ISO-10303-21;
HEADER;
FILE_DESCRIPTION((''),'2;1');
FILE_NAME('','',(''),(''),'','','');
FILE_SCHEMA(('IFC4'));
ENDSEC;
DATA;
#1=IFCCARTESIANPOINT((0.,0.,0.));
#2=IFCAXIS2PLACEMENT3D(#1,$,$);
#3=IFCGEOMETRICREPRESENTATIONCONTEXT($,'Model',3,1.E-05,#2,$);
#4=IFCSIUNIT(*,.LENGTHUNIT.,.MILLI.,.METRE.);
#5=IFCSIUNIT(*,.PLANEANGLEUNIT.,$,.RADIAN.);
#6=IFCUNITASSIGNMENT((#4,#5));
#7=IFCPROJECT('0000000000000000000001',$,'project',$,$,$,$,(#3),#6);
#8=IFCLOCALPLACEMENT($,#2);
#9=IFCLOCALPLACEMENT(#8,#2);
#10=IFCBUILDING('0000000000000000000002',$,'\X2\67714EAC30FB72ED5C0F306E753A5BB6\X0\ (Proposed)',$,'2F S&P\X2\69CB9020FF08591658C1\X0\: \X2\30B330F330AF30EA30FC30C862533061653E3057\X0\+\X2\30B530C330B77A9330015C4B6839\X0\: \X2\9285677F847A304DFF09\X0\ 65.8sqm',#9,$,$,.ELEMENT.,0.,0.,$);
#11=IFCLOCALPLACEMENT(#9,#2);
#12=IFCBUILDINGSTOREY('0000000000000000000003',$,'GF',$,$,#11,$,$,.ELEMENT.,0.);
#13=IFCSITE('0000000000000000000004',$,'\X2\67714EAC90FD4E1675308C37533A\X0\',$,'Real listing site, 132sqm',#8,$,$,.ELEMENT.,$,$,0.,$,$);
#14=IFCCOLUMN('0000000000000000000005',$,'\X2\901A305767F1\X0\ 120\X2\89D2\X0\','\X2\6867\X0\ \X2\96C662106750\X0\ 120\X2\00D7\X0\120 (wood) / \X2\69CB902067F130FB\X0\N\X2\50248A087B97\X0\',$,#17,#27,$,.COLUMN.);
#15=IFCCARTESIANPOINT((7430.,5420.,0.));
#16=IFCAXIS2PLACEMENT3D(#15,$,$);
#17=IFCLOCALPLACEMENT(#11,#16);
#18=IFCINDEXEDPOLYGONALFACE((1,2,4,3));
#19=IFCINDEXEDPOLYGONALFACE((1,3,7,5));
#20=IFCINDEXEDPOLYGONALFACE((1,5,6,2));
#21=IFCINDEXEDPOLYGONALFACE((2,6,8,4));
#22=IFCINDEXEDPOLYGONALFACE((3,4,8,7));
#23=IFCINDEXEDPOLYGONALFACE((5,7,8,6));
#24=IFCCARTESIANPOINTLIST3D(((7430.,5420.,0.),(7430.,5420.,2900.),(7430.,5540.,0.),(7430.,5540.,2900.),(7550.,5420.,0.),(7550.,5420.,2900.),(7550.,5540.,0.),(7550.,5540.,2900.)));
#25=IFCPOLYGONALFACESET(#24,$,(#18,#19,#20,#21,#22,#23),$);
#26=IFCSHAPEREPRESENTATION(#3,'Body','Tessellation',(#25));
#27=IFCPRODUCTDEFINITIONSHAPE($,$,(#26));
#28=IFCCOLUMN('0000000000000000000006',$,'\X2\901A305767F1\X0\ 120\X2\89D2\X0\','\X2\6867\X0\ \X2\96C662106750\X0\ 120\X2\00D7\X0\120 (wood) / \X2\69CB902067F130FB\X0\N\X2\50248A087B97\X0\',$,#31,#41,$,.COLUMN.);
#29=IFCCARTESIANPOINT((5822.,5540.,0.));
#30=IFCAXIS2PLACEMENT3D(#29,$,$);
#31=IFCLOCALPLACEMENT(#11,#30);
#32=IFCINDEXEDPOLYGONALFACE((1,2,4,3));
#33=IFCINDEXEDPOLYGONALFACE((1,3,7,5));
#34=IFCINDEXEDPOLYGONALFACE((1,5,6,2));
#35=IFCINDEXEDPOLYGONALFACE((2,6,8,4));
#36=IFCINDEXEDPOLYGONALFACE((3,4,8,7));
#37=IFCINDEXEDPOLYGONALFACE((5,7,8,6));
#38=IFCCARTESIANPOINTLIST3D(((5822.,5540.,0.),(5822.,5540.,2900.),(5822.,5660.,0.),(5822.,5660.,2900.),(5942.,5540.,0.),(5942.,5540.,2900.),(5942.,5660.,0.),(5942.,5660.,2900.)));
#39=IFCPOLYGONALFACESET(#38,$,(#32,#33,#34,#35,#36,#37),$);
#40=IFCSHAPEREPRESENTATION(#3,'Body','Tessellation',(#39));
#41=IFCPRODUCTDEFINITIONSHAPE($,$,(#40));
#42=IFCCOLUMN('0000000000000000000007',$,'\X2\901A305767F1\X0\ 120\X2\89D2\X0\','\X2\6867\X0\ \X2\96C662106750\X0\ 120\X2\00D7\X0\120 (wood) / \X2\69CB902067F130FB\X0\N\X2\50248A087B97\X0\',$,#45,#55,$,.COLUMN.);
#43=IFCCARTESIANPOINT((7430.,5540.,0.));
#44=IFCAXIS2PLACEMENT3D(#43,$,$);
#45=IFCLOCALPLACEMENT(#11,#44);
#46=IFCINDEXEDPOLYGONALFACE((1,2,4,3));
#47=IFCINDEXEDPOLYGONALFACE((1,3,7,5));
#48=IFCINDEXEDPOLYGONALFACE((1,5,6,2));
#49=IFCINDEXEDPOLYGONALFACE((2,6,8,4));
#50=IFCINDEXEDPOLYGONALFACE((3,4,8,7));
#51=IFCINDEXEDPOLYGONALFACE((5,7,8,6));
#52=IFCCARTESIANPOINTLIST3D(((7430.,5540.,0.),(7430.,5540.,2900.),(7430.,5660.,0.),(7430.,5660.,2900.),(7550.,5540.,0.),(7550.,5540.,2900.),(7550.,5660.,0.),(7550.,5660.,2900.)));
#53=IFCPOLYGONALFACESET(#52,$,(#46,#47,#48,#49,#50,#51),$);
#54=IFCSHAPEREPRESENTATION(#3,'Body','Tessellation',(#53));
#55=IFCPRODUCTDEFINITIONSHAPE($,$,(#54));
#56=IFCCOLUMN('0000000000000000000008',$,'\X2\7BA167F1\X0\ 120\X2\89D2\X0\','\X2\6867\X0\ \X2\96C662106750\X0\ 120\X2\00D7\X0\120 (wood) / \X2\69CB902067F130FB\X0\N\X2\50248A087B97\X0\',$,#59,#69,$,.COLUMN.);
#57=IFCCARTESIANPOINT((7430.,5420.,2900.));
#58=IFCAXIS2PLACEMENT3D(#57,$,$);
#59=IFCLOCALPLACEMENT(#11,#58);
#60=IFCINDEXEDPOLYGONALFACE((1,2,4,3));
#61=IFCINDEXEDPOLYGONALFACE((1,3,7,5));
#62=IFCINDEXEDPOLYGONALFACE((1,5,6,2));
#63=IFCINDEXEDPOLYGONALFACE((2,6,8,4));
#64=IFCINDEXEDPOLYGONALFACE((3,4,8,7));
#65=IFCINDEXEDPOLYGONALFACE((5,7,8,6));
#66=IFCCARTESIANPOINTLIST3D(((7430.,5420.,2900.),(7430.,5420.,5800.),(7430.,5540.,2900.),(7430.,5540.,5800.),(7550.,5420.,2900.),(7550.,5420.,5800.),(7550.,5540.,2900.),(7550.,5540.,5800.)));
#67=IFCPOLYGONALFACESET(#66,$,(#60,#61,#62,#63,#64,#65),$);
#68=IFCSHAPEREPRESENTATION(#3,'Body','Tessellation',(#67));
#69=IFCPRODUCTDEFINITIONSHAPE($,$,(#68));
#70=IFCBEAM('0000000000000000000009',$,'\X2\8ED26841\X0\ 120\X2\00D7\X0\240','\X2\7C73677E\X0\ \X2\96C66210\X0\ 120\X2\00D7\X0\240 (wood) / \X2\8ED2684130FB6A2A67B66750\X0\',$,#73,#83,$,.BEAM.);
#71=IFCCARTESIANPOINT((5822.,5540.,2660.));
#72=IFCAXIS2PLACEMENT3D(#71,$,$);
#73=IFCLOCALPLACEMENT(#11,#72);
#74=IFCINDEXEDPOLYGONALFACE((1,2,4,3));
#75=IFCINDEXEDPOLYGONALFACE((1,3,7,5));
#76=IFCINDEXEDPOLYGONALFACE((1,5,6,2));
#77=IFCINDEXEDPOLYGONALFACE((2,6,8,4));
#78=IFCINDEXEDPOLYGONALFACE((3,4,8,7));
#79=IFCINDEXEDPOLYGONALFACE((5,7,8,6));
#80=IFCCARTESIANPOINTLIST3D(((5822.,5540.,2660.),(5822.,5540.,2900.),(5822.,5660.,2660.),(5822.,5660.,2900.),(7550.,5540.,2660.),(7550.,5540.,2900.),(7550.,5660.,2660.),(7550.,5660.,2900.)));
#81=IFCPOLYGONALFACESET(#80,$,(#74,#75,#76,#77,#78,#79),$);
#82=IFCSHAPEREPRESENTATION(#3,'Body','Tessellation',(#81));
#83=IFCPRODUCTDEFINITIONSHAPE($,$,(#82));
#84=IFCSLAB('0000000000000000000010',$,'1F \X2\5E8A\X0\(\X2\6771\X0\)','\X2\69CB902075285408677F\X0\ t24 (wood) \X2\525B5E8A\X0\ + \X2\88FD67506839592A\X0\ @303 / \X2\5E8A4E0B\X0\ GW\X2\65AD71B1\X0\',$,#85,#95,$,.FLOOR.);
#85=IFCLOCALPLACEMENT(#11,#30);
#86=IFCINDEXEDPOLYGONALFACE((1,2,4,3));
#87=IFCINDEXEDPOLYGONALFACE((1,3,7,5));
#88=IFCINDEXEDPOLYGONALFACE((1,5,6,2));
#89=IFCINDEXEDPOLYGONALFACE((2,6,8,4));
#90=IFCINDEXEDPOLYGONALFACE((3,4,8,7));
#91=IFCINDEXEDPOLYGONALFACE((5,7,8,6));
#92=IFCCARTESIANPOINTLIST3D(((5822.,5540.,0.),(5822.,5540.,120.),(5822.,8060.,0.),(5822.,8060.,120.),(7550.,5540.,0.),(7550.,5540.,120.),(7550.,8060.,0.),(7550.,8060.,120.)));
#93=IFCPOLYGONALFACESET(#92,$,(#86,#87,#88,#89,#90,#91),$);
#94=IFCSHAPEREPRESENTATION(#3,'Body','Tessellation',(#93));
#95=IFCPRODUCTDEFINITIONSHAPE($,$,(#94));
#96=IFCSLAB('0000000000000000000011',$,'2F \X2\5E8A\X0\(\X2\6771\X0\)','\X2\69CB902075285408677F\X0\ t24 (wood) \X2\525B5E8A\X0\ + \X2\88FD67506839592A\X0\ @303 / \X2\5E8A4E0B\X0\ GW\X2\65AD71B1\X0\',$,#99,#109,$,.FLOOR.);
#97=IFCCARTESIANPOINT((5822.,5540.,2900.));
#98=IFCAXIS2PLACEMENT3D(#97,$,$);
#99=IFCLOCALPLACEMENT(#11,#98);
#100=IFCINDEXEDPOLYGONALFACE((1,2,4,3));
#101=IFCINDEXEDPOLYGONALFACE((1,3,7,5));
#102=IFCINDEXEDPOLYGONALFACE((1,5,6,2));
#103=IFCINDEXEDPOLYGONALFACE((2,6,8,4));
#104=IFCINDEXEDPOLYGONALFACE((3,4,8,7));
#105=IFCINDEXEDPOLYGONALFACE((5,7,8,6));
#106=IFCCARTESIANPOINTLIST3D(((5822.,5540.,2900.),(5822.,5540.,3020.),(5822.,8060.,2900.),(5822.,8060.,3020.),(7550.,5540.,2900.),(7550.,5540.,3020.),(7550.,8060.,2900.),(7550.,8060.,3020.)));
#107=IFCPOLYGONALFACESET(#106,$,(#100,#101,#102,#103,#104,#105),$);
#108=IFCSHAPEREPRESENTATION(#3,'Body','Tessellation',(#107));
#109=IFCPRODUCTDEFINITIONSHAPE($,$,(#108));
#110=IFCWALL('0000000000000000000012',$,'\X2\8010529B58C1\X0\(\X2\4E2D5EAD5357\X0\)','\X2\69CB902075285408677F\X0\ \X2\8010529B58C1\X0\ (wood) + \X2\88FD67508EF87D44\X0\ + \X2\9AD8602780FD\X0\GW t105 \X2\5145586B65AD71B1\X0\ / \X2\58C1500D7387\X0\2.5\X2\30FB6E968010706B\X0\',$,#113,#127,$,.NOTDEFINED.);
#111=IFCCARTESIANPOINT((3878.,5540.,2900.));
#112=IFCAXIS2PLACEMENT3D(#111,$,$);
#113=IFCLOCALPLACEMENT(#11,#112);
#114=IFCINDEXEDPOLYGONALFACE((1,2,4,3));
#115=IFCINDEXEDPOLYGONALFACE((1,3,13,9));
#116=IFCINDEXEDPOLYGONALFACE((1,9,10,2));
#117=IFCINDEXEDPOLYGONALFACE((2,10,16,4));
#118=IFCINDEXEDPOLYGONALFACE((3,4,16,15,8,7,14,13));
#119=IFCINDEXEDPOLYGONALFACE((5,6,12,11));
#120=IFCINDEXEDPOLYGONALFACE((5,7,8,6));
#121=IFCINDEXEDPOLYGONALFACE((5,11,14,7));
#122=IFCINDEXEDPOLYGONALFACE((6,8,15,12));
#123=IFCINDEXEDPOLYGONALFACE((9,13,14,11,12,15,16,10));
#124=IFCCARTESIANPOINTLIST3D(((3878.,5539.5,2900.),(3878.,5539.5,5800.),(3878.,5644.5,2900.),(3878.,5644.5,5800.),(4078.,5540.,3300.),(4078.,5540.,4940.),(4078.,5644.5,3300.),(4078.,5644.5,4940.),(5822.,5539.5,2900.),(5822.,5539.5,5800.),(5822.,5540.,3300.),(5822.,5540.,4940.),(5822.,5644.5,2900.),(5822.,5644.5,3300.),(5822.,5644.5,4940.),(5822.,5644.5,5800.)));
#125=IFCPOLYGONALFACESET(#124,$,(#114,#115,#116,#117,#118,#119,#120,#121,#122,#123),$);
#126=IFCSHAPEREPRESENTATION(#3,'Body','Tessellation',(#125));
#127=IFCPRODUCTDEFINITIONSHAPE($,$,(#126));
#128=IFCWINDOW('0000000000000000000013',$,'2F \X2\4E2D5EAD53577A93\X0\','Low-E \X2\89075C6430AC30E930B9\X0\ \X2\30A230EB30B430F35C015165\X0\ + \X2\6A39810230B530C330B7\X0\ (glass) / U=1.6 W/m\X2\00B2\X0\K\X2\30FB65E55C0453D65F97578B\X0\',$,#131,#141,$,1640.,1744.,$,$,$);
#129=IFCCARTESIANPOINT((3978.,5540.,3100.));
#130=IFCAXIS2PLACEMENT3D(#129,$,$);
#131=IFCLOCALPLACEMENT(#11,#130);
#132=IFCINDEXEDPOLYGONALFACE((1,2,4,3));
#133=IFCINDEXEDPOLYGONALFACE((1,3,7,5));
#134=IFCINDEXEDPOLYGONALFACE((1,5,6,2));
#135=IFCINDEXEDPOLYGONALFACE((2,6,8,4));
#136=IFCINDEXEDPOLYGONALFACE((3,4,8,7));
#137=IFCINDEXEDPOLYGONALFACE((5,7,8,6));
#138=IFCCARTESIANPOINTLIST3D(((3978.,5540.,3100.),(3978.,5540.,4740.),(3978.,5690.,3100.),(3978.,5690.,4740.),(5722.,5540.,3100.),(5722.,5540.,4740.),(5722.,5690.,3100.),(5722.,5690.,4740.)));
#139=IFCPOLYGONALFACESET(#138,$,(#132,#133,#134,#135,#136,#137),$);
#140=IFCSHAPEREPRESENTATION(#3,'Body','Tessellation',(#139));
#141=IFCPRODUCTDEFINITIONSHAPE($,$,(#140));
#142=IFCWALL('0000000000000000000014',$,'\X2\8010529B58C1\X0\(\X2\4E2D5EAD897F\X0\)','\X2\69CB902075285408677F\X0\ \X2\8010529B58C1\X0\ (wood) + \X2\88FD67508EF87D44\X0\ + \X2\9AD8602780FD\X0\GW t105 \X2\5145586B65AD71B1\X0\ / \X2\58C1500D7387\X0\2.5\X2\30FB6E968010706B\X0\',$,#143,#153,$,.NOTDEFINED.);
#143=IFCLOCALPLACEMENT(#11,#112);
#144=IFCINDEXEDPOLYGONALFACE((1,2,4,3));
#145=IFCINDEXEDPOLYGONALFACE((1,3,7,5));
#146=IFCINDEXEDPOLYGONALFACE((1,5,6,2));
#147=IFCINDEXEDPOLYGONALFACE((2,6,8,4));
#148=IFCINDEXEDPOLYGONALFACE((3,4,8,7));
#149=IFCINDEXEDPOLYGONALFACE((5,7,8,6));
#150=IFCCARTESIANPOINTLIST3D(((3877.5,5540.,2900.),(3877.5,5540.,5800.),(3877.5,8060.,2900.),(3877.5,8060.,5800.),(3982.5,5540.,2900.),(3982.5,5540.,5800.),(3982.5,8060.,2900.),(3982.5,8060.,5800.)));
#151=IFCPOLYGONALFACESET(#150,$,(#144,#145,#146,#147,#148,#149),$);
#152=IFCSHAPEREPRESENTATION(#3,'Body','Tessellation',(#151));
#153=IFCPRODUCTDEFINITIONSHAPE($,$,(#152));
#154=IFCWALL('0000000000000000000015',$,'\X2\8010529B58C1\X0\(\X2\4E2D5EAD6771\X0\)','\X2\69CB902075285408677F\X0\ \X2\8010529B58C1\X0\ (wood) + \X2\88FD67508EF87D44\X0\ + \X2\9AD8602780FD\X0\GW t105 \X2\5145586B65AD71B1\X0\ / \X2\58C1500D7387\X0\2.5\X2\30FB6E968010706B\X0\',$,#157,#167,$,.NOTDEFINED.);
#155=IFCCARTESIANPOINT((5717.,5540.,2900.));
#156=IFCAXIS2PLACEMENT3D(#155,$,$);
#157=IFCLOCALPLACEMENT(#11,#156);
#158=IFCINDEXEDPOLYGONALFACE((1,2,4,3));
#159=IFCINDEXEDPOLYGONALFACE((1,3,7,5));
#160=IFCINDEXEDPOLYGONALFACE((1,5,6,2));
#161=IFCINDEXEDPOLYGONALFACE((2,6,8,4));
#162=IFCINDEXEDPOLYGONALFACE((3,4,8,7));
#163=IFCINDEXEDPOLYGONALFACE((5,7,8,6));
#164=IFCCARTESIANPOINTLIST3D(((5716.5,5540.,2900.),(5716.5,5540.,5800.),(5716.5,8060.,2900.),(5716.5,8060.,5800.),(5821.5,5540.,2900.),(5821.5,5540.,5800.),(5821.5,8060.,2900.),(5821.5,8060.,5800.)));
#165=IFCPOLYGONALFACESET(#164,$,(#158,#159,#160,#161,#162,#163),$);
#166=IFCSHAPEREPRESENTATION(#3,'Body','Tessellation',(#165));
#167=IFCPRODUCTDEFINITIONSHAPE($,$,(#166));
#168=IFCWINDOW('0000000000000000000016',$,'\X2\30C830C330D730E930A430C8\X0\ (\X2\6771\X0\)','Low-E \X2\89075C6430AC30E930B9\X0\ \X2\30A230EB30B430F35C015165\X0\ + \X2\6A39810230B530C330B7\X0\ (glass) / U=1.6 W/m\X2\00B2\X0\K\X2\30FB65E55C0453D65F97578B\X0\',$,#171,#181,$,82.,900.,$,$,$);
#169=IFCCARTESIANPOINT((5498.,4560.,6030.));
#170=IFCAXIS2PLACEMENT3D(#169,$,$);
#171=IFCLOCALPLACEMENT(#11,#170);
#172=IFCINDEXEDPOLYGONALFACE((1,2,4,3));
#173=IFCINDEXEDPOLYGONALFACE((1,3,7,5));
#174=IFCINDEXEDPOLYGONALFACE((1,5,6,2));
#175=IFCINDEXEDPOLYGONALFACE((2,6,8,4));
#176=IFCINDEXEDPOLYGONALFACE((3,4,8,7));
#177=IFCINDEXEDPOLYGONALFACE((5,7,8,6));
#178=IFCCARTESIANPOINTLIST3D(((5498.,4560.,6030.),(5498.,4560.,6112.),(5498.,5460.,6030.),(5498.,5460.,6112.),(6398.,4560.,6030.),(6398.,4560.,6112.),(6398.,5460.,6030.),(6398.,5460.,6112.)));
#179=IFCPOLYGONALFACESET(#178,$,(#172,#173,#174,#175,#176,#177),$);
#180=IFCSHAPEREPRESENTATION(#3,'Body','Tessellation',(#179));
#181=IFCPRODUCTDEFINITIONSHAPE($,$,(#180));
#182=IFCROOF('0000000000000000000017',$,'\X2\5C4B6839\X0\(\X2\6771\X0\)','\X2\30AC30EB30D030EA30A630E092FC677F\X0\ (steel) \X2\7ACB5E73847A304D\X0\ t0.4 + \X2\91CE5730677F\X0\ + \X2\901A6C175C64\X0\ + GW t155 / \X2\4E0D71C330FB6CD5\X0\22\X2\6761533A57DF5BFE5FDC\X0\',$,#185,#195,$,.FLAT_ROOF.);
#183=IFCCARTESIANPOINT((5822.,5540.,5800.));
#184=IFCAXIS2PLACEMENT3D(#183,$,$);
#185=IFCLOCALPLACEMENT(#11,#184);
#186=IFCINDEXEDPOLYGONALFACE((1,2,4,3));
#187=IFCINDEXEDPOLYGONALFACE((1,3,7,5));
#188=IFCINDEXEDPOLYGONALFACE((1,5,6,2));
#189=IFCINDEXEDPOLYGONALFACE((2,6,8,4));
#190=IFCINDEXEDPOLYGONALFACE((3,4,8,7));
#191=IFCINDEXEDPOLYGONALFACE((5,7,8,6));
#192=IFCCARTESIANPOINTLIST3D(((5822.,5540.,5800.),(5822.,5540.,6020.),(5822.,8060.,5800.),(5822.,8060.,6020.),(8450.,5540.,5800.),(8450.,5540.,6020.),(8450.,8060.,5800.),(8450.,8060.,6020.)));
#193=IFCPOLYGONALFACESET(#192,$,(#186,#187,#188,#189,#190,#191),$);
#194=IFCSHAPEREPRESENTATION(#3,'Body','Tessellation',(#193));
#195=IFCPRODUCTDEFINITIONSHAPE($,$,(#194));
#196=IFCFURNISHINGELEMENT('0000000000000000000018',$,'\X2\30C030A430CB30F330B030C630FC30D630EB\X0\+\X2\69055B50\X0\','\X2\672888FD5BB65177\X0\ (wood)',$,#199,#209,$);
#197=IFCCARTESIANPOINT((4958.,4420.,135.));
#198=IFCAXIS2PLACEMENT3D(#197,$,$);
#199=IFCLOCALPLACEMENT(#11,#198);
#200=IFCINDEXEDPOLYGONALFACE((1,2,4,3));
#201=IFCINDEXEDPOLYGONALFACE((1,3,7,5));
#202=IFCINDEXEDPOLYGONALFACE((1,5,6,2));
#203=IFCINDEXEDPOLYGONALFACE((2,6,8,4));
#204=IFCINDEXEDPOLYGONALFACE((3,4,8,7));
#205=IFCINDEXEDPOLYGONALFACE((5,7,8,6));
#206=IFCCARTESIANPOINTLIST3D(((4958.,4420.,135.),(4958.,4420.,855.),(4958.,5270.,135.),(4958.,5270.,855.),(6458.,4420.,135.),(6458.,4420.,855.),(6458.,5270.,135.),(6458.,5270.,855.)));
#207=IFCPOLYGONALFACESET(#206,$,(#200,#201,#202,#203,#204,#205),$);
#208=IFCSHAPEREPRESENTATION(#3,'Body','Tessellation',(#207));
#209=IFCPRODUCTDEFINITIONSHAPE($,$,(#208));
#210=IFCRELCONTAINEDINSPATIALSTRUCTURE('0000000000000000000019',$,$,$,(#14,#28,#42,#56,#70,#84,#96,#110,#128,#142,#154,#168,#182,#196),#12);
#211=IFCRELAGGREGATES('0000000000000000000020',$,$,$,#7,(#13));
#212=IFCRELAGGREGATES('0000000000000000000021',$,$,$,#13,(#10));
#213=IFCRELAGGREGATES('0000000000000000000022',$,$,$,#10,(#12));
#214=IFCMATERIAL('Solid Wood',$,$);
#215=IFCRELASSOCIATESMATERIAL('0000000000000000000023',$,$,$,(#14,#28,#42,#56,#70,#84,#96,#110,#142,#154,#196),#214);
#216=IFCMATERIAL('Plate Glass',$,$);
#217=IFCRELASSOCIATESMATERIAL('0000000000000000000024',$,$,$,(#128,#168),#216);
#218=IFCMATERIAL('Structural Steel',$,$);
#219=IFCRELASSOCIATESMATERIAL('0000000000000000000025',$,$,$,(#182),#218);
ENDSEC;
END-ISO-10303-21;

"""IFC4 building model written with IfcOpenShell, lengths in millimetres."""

from ifc_helpers import new_model, si_unit, frame, frame_2d, origin, place, context, project, spatial, rectangle, extrude, material, element, fill, save


model = new_model("IFC4")

# Units and contexts
model_context = context("Model", 3, precision=1e-05, world=origin())
ifc_project = project(units=[si_unit("LENGTHUNIT", "METRE", prefix="MILLI"), si_unit("PLANEANGLEUNIT", "RADIAN")], contexts=[model_context])

# Site, building, storey
site_placement = place(None, origin())
site = spatial("IfcSite", under=ifc_project, at=site_placement, Name="東京都世田谷区", ObjectType="Real listing site, 132sqm", CompositionType="ELEMENT", RefElevation=0.0)
building_placement = place(site_placement, origin())
building = spatial("IfcBuilding", under=site, at=building_placement, Name="東京・狭小の町家 (Proposed)", ObjectType="2F S&P構造（外壁: コンクリート打ち放し+サッシ窓、屋根: 銅板葺き） 65.8sqm", CompositionType="ELEMENT", ElevationOfRefHeight=0.0, ElevationOfTerrain=0.0)
storey_placement = place(building_placement, origin())
storey = spatial("IfcBuildingStorey", under=building, at=storey_placement, Name="GF", CompositionType="ELEMENT", Elevation=0.0)

# Columns
ifc_material_1 = material(Name="Solid Wood")
column_1_placement = place(storey_placement, frame((7430.0, 5420.0, 0.0)))
element("IfcColumn", 1, at=column_1_placement, inside=storey, material=ifc_material_1, Name="通し柱 120角", Description="桧 集成材 120×120 (wood) / 構造柱・N値計算", PredefinedType="COLUMN", context=model_context, shape_type="SweptSolid", body=[
    extrude(rectangle(XDim=120.0, YDim=120.0, at=frame_2d((60.0, 60.0))), frame((7430.0, 5420.0, 0.0)), (0.0, 0.0, 1.0), 2900.0),
])
column_2_placement = place(storey_placement, frame((5822.0, 5540.0, 0.0)))
element("IfcColumn", 2, at=column_2_placement, inside=storey, material=ifc_material_1, Name="通し柱 120角", Description="桧 集成材 120×120 (wood) / 構造柱・N値計算", PredefinedType="COLUMN", context=model_context, shape_type="SweptSolid", body=[
    extrude(rectangle(XDim=120.0, YDim=120.0, at=frame_2d((60.0, 60.0))), frame((5822.0, 5540.0, 0.0)), (0.0, 0.0, 1.0), 2900.0),
])
column_3_placement = place(storey_placement, frame((7430.0, 5540.0, 0.0)))
element("IfcColumn", 3, at=column_3_placement, inside=storey, material=ifc_material_1, Name="通し柱 120角", Description="桧 集成材 120×120 (wood) / 構造柱・N値計算", PredefinedType="COLUMN", context=model_context, shape_type="SweptSolid", body=[
    extrude(rectangle(XDim=120.0, YDim=120.0, at=frame_2d((60.0, 60.0))), frame((7430.0, 5540.0, 0.0)), (0.0, 0.0, 1.0), 2900.0),
])
column_4_placement = place(storey_placement, frame((7430.0, 5420.0, 2900.0)))
element("IfcColumn", 4, at=column_4_placement, inside=storey, material=ifc_material_1, Name="管柱 120角", Description="桧 集成材 120×120 (wood) / 構造柱・N値計算", PredefinedType="COLUMN", context=model_context, shape_type="SweptSolid", body=[
    extrude(rectangle(XDim=120.0, YDim=120.0, at=frame_2d((60.0, 60.0))), frame((7430.0, 5420.0, 2900.0)), (0.0, 0.0, 1.0), 2900.0),
])

# Beam
beam_1_placement = place(storey_placement, frame((5822.0, 5540.0, 2660.0)))
element("IfcBeam", 5, at=beam_1_placement, inside=storey, material=ifc_material_1, Name="軒桁 120×240", Description="米松 集成 120×240 (wood) / 軒桁・横架材", PredefinedType="BEAM", context=model_context, shape_type="SweptSolid", body=[
    extrude(rectangle(XDim=1728.0, YDim=120.0, at=frame_2d((864.0, 60.0))), frame((5822.0, 5540.0, 2660.0)), (0.0, 0.0, 1.0), 240.0),
])

# Slabs
slab_1_placement = place(storey_placement, frame((5822.0, 5540.0, 0.0)))
element("IfcSlab", 6, at=slab_1_placement, inside=storey, material=ifc_material_1, Name="1F 床(東)", Description="構造用合板 t24 (wood) 剛床 + 製材根太 @303 / 床下 GW断熱", PredefinedType="FLOOR", context=model_context, shape_type="SweptSolid", body=[
    extrude(rectangle(XDim=1728.0, YDim=2520.0, at=frame_2d((864.0, 1260.0))), frame((5822.0, 5540.0, 0.0)), (0.0, 0.0, 1.0), 120.0),
])
slab_2_placement = place(storey_placement, frame((5822.0, 5540.0, 2900.0)))
element("IfcSlab", 7, at=slab_2_placement, inside=storey, material=ifc_material_1, Name="2F 床(東)", Description="構造用合板 t24 (wood) 剛床 + 製材根太 @303 / 床下 GW断熱", PredefinedType="FLOOR", context=model_context, shape_type="SweptSolid", body=[
    extrude(rectangle(XDim=1728.0, YDim=2520.0, at=frame_2d((864.0, 1260.0))), frame((5822.0, 5540.0, 2900.0)), (0.0, 0.0, 1.0), 120.0),
])

# Wall, opening, window
wall_1_placement = place(storey_placement, frame((3878.0, 5540.0, 2900.0)))
wall_1 = element("IfcWall", 8, at=wall_1_placement, inside=storey, material=ifc_material_1, Name="耐力壁(中庭南)", Description="構造用合板 耐力壁 (wood) + 製材軸組 + 高性能GW t105 充填断熱 / 壁倍率2.5・準耐火", PredefinedType="NOTDEFINED", context=model_context, shape_type="SweptSolid", body=[
    extrude(rectangle(XDim=1944.0, YDim=105.0, at=frame_2d((972.0, 52.0))), frame((3878.0, 5540.0, 2900.0)), (0.0, 0.0, 1.0), 2900.0),
])
opening_placement = place(storey_placement, frame((3978.0, 5540.0, 3100.0)))
opening = element("IfcOpeningElement", 9, at=opening_placement, cuts=wall_1, PredefinedType="NOTDEFINED", context=model_context, shape_type="SweptSolid", body=[
    extrude(rectangle(XDim=1744.0, YDim=150.0, at=frame_2d((872.0, 75.0))), frame((3978.0, 5540.0, 3100.0)), (0.0, 0.0, 1.0), 1640.0),
])
ifc_material_2 = material(Name="Plate Glass")
window_1_placement = place(storey_placement, frame((3978.0, 5540.0, 3100.0)))
window_1 = element("IfcWindow", 10, at=window_1_placement, inside=storey, material=ifc_material_2, Name="2F 中庭南窓", Description="Low-E 複層ガラス アルゴン封入 + 樹脂サッシ (glass) / U=1.6 W/m²K・日射取得型", OverallHeight=1640.0, OverallWidth=1744.0, context=model_context, shape_type="SweptSolid", body=[
    extrude(rectangle(XDim=1744.0, YDim=150.0, at=frame_2d((872.0, 75.0))), frame((3978.0, 5540.0, 3100.0)), (0.0, 0.0, 1.0), 1640.0),
])
fill(opening, window_1)

# Walls
wall_2_placement = place(storey_placement, frame((3878.0, 5540.0, 2900.0)))
element("IfcWall", 11, at=wall_2_placement, inside=storey, material=ifc_material_1, Name="耐力壁(中庭西)", Description="構造用合板 耐力壁 (wood) + 製材軸組 + 高性能GW t105 充填断熱 / 壁倍率2.5・準耐火", PredefinedType="NOTDEFINED", context=model_context, shape_type="SweptSolid", body=[
    extrude(rectangle(XDim=105.0, YDim=2520.0, at=frame_2d((52.0, 1260.0))), frame((3878.0, 5540.0, 2900.0)), (0.0, 0.0, 1.0), 2900.0),
])
wall_3_placement = place(storey_placement, frame((5717.0, 5540.0, 2900.0)))
element("IfcWall", 12, at=wall_3_placement, inside=storey, material=ifc_material_1, Name="耐力壁(中庭東)", Description="構造用合板 耐力壁 (wood) + 製材軸組 + 高性能GW t105 充填断熱 / 壁倍率2.5・準耐火", PredefinedType="NOTDEFINED", context=model_context, shape_type="SweptSolid", body=[
    extrude(rectangle(XDim=105.0, YDim=2520.0, at=frame_2d((52.0, 1260.0))), frame((5717.0, 5540.0, 2900.0)), (0.0, 0.0, 1.0), 2900.0),
])

# Window
window_2_placement = place(storey_placement, frame((5498.0, 4560.0, 6030.0)))
element("IfcWindow", 13, at=window_2_placement, inside=storey, material=ifc_material_2, Name="トップライト (東)", Description="Low-E 複層ガラス アルゴン封入 + 樹脂サッシ (glass) / U=1.6 W/m²K・日射取得型", OverallHeight=82.0, OverallWidth=900.0, context=model_context, shape_type="SweptSolid", body=[
    extrude(rectangle(XDim=900.0, YDim=900.0, at=frame_2d((450.0, 450.0))), frame((5498.0, 4560.0, 6030.0)), (0.0, 0.0, 1.0), 82.0),
])

# Roof
ifc_material_3 = material(Name="Structural Steel")
for number, where, name in (
    (14, (5822.0, 5540.0, 5800.0), "屋根(東)"),
):
    element("IfcRoof", number, at=place(storey_placement, frame(where)), inside=storey, material=ifc_material_3, Name=name, Description="ガルバリウム鋼板 (steel) 立平葺き t0.4 + 野地板 + 通気層 + GW t155 / 不燃・法22条区域対応", PredefinedType="FLAT_ROOF", context=model_context, shape_type="SweptSolid", body=[
        extrude(rectangle(XDim=2628.0, YDim=2520.0, at=frame_2d((1314.0, 1260.0))), frame((5822.0, 5540.0, 5800.0)), (0.0, 0.0, 1.0), 220.0),
    ])

# Furnishing element
furnishing_1_placement = place(storey_placement, frame((4958.0, 4420.0, 135.0)))
element("IfcFurnishingElement", 15, at=furnishing_1_placement, inside=storey, material=ifc_material_1, Name="ダイニングテーブル+椅子", Description="木製家具 (wood)", context=model_context, shape_type="SweptSolid", body=[
    extrude(rectangle(XDim=1500.0, YDim=850.0, at=frame_2d((750.0, 425.0))), frame((4958.0, 4420.0, 135.0)), (0.0, 0.0, 1.0), 720.0),
])

save(model, "model.ifc")
